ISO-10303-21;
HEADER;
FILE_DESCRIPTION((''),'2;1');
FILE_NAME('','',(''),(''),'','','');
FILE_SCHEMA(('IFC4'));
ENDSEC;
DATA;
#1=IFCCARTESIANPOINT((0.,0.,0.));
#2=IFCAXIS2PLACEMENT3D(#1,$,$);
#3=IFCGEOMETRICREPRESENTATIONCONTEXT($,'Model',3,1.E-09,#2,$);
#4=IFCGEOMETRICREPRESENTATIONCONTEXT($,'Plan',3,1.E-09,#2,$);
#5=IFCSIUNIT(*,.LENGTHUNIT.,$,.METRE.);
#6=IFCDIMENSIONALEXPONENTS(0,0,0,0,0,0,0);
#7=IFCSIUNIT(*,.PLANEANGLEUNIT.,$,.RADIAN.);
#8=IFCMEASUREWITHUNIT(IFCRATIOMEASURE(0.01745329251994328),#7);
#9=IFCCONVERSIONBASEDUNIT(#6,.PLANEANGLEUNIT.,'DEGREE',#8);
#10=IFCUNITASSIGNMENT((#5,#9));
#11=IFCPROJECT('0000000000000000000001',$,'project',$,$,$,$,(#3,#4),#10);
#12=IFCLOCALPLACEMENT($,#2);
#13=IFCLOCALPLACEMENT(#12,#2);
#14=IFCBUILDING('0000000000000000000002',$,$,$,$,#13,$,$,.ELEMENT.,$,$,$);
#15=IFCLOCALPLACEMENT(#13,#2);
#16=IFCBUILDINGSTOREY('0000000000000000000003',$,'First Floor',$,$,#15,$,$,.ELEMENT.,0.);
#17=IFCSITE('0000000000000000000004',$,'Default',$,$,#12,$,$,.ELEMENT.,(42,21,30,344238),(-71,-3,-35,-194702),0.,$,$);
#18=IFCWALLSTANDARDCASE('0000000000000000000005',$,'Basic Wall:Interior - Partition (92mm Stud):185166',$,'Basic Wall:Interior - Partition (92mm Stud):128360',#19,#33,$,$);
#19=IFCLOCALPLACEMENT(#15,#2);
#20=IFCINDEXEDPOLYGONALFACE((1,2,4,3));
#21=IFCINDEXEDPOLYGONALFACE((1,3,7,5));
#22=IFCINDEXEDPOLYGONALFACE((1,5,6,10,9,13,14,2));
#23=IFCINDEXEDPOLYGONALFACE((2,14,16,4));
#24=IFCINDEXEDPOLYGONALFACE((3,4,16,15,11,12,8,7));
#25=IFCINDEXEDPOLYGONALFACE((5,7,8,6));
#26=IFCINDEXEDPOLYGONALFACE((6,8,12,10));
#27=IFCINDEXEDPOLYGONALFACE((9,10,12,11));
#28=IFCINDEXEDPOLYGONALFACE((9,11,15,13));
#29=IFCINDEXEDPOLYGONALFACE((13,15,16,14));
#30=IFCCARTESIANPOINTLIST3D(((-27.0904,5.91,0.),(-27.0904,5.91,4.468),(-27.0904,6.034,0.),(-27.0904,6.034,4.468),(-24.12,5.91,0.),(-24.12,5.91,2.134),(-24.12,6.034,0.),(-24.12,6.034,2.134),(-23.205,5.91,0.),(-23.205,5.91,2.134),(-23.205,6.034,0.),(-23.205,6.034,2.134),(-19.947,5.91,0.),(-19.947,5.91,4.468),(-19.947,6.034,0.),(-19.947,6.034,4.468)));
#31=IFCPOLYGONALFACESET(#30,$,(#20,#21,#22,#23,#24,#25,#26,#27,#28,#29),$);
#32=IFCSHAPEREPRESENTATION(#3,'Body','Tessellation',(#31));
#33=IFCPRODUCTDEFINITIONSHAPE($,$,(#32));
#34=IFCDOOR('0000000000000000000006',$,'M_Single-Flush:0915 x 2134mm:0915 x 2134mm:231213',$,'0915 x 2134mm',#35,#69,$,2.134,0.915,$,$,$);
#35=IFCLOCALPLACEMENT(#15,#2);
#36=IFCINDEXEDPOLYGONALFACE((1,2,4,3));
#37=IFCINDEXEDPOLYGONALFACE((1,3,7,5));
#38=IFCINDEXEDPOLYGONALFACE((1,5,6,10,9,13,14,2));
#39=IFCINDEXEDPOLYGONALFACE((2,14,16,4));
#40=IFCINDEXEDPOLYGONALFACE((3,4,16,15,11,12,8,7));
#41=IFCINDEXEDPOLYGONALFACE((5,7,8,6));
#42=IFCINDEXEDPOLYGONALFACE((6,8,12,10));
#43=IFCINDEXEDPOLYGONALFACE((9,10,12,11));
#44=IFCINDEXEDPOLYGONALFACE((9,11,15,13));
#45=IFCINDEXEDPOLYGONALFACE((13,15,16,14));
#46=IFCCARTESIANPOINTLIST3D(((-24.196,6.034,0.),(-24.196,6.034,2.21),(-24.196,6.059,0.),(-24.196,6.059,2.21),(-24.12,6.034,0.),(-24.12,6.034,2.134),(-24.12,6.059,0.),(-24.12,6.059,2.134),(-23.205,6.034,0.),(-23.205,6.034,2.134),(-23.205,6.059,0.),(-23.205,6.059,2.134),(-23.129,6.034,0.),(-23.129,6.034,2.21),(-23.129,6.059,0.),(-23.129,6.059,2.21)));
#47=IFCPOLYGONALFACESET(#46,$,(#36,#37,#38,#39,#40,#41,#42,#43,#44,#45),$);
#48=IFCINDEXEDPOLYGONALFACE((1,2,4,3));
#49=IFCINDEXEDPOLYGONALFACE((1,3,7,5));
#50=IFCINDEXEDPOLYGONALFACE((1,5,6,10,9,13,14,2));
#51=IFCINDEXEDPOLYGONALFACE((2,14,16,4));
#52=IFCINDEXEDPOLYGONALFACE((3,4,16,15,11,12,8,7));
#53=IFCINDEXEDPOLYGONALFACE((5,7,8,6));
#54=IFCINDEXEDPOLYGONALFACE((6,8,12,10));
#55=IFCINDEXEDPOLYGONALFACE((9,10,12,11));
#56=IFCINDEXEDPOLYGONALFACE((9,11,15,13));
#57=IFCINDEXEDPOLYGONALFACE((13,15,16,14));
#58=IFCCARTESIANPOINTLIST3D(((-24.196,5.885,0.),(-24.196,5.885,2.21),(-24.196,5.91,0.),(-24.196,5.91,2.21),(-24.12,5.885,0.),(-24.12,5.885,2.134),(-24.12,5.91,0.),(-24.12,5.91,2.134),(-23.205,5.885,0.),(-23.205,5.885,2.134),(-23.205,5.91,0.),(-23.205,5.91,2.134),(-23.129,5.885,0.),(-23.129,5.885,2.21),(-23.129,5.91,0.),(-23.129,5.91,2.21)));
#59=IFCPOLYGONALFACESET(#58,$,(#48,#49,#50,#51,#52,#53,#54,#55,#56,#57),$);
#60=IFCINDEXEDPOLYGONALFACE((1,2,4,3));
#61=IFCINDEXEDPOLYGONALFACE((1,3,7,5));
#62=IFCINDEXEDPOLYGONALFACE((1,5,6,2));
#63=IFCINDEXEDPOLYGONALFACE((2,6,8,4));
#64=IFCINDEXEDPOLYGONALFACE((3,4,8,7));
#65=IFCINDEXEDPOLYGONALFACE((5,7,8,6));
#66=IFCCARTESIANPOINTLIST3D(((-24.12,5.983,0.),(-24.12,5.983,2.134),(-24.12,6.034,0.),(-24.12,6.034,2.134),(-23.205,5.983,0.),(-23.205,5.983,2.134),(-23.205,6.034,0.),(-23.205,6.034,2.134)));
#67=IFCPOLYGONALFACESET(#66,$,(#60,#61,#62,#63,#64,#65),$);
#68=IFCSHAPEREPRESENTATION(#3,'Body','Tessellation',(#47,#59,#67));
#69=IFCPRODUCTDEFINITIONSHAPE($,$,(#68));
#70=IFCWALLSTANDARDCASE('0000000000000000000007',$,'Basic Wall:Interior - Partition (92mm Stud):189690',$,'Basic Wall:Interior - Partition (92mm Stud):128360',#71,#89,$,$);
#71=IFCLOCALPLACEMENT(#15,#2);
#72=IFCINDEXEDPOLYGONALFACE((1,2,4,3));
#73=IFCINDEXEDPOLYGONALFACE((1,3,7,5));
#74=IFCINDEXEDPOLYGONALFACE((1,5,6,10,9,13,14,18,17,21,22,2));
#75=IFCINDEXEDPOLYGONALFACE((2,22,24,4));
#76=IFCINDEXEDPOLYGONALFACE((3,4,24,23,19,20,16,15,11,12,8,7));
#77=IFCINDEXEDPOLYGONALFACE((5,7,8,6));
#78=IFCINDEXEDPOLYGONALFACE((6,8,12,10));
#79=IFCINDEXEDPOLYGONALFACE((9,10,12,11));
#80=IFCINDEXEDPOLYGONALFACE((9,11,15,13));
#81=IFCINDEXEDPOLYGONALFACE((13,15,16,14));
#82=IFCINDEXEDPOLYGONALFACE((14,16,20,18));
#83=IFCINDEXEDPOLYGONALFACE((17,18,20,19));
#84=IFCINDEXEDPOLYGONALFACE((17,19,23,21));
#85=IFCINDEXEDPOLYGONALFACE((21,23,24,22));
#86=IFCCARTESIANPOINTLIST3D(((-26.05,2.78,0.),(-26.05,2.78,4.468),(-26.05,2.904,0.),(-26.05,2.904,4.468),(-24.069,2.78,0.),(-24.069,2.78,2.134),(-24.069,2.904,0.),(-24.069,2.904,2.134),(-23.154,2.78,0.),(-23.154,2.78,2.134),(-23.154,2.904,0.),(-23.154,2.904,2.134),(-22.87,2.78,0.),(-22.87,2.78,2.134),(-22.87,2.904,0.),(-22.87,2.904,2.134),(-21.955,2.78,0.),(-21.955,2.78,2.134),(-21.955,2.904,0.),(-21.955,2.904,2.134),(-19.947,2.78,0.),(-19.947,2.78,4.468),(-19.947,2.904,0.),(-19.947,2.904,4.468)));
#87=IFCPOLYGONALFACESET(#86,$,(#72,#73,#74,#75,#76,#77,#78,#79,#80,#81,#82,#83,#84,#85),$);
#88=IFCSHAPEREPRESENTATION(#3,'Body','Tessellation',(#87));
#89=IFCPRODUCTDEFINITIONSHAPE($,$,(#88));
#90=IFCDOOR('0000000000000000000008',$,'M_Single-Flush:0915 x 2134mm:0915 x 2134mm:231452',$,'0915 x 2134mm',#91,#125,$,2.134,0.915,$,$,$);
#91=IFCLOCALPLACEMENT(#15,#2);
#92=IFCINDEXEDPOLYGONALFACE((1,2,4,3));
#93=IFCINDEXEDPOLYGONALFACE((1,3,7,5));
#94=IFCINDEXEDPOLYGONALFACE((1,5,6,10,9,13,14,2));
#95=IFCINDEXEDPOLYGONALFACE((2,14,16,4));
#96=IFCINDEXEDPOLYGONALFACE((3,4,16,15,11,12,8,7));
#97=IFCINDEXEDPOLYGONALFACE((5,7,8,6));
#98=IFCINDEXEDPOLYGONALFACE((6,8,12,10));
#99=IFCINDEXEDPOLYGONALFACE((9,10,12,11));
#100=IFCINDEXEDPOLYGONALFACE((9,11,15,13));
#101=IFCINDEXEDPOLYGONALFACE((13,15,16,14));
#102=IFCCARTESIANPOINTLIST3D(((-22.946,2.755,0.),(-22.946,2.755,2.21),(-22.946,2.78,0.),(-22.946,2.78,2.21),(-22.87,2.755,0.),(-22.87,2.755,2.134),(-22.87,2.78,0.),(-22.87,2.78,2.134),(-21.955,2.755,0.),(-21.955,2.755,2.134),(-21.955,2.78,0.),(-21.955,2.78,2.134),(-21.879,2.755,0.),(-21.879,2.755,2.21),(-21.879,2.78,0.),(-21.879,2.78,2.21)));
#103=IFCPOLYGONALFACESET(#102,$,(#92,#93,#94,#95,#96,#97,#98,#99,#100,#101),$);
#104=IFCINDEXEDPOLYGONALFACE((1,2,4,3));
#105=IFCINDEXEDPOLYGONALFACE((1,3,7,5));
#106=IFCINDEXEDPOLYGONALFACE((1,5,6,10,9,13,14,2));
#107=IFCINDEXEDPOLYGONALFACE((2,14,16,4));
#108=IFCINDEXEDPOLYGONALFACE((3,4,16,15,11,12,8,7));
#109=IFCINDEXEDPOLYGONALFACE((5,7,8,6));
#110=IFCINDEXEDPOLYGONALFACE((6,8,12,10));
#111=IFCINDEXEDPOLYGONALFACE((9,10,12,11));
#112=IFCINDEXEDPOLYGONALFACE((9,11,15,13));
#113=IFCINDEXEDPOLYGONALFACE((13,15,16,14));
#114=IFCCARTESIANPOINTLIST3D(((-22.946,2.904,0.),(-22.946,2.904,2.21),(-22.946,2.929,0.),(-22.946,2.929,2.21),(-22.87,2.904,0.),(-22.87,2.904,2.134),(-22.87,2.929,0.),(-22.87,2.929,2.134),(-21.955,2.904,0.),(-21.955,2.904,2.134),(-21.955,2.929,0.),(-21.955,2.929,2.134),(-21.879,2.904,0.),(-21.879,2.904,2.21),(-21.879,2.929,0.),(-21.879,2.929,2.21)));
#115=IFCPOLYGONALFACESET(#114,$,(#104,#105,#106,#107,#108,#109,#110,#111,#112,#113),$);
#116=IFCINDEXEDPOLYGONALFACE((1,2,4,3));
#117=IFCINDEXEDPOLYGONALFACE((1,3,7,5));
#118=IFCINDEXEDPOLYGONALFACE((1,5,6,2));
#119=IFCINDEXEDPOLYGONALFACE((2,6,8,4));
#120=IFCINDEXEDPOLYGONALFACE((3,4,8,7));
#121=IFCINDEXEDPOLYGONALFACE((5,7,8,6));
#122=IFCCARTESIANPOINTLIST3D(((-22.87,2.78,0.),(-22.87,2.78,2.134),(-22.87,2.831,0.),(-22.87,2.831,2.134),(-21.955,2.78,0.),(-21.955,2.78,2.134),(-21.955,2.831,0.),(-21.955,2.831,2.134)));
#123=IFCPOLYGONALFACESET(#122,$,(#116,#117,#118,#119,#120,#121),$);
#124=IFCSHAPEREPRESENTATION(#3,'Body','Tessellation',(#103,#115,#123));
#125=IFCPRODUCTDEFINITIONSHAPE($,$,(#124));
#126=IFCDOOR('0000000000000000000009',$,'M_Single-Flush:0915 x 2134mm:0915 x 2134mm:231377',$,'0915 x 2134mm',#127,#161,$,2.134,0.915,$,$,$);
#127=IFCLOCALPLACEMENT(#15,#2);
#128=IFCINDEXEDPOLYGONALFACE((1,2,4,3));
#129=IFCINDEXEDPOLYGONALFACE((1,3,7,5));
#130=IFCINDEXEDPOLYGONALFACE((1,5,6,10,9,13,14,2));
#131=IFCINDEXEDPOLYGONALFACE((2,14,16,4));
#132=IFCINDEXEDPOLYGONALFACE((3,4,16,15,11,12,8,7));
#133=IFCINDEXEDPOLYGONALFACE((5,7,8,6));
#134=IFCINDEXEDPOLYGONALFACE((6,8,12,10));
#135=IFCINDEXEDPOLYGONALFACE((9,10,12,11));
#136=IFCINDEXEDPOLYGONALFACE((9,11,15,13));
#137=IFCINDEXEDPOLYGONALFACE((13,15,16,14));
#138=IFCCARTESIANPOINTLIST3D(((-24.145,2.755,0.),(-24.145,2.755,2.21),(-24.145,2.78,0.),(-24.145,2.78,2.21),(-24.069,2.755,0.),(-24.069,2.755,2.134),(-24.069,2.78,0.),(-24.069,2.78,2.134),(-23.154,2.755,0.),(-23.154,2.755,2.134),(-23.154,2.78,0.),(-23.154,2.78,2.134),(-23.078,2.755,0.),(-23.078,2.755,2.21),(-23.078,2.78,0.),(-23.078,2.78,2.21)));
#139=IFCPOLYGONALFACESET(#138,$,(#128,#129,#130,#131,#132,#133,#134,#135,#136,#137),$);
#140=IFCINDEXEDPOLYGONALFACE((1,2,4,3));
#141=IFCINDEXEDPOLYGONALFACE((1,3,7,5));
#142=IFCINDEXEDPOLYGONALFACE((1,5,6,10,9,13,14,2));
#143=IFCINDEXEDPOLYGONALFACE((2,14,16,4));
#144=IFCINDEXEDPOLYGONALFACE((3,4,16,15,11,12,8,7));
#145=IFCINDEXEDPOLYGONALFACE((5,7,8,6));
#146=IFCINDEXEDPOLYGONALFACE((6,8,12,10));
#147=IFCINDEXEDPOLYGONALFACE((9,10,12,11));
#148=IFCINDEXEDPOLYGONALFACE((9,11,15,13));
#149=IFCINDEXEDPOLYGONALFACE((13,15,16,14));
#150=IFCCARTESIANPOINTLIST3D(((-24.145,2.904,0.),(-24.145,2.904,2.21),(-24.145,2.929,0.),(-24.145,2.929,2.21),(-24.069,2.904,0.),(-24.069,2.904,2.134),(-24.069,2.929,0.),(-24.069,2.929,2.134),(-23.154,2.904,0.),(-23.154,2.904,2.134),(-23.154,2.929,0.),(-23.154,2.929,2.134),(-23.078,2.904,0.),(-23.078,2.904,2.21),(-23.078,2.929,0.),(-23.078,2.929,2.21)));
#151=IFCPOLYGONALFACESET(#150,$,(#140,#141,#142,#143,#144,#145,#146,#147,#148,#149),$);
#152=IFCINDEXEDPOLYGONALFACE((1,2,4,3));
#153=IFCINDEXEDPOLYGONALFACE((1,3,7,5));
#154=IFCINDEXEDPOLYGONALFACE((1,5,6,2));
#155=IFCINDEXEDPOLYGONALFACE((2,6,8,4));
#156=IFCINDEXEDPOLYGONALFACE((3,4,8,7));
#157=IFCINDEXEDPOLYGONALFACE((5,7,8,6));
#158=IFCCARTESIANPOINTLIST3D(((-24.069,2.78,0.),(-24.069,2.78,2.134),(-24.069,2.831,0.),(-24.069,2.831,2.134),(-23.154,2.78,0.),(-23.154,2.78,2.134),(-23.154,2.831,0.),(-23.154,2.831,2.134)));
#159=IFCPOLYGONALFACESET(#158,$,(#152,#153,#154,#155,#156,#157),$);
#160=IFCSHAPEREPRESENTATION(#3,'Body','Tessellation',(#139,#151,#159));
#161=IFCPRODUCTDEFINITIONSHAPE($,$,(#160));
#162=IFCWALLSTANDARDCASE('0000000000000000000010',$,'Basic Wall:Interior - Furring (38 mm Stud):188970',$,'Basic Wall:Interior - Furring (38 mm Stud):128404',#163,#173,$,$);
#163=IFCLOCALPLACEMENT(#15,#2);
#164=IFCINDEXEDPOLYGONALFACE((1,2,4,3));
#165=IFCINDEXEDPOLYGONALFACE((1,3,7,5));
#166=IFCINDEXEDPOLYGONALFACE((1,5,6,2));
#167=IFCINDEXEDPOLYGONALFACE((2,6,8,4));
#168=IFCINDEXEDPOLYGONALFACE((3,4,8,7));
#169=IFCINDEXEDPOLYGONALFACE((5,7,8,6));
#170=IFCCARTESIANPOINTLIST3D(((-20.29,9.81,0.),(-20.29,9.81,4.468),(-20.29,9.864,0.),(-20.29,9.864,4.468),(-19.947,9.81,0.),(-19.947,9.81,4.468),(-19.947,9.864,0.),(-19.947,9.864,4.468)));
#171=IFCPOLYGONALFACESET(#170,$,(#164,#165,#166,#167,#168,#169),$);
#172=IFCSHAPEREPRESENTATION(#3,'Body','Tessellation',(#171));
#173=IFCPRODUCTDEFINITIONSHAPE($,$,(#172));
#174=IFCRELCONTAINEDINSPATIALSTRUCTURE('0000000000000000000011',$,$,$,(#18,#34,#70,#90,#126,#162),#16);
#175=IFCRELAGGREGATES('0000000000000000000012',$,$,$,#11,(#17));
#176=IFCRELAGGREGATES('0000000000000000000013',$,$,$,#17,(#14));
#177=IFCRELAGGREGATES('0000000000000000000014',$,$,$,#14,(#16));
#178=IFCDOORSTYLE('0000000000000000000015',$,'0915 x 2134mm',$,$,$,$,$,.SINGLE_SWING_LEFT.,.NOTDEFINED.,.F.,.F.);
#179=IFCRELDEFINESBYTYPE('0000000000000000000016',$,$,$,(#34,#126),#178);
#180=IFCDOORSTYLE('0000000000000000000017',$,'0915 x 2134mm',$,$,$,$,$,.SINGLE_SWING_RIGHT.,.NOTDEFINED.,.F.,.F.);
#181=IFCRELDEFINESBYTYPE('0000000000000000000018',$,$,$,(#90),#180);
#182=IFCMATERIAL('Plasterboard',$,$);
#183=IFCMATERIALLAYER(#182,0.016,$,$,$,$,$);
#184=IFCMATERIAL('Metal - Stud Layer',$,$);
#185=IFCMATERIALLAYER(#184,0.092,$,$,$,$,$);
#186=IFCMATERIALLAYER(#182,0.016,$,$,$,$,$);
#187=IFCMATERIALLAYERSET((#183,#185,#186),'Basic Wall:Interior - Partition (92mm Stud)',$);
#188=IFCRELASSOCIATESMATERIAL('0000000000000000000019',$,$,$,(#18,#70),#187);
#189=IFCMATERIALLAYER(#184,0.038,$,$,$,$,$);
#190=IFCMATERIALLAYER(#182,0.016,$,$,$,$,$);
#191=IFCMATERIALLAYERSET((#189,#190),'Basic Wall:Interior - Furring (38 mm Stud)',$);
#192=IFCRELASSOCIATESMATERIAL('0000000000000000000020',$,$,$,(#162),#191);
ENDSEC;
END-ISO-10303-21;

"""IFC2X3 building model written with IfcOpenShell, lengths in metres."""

from ifc_helpers import new_model, entity, si_unit, converted_unit, frame, frame_2d, origin, origin_2d_with_axis, place, context, project, spatial, polyline, rectangle, outline, extrude, source, transform, mapped, material, layer, layer_set, layer_usage, type_object, type_shapes, element, fill, save


model = new_model("IFC2X3")

# Units and contexts
model_context = context("Model", 3, precision=1e-09, world=origin())
plan_context = context("Plan", 3, precision=1e-09, world=origin())
ifc_project = project(units=[si_unit("LENGTHUNIT", "METRE"), converted_unit("PLANEANGLEUNIT", "DEGREE", entity("IfcRatioMeasure", 0.01745329251994328), si_unit("PLANEANGLEUNIT", "RADIAN"), dimensions=[0, 0, 0, 0, 0, 0, 0])], contexts=[model_context, plan_context])

# Site, building, storey
site_placement = place(None, origin())
site = spatial("IfcSite", under=ifc_project, at=site_placement, Name="Default", CompositionType="ELEMENT", RefLatitude=(42, 21, 30, 344238), RefLongitude=(-71, -3, -35, -194702), RefElevation=0.0)
building_placement = place(site_placement, origin())
building = spatial("IfcBuilding", under=site, at=building_placement, CompositionType="ELEMENT")
storey_placement = place(building_placement, origin())
storey = spatial("IfcBuildingStorey", under=building, at=storey_placement, Name="First Floor", CompositionType="ELEMENT", Elevation=0.0)

# Shared definitions
ifc_material_1 = material(Name="Metal - Stud Layer")
ifc_material_2 = material(Name="Plasterboard")

# Wall, opening, door
ifc_layer_1 = layer(ifc_material_2, 0.016)
ifc_layer_2 = layer(ifc_material_1, 0.092)
ifc_layer_3 = layer(ifc_material_2, 0.016)
ifc_layer_set_1 = layer_set([ifc_layer_1, ifc_layer_2, ifc_layer_3], Name="Basic Wall:Interior - Partition (92mm Stud)")
ifc_layer_usage_1 = layer_usage(ifc_layer_set_1, "AXIS2", "NEGATIVE", 0.062)
wall_1_placement = place(storey_placement, frame((-19.947, 5.972, 0.0), z_axis=(0.0, 0.0, 1.0), x_axis=(-1.0, 0.0, 0.0)))
wall_1 = element("IfcWallStandardCase", 1, at=wall_1_placement, inside=storey, material=ifc_layer_usage_1, Name="Basic Wall:Interior - Partition (92mm Stud):185166", ObjectType="Basic Wall:Interior - Partition (92mm Stud):128360", context=model_context, shape_type="SweptSolid", body=[
    extrude(rectangle(XDim=7.1434, YDim=0.124, at=frame_2d((3.5717, 0.0), x_axis=(-1.0, 0.0))), origin(), (0.0, 0.0, 1.0), 4.468),
])
opening_1_placement = place(wall_1_placement, frame((4.173, 0.062, 0.0)))
opening_1 = element("IfcOpeningElement", 2, at=opening_1_placement, cuts=wall_1, ObjectType="Opening", context=model_context, shape_type="SweptSolid", body=[
    extrude(rectangle(XDim=0.915, YDim=2.134, at=frame_2d((1.067, 0.4575), x_axis=(0.0, -1.0))), frame((0.0, 0.0, 0.0), z_axis=(0.0, -1.0, 0.0), x_axis=(0.0, 0.0, 1.0)), (0.0, 0.0, 1.0), 0.124),
])
door_style_1 = type_object("IfcDoorStyle", Name="0915 x 2134mm", ConstructionType="NOTDEFINED", OperationType="SINGLE_SWING_LEFT", ParameterTakesPrecedence=False, Sizeable=False)
shared_shape_1 = source(origin(), model_context, "Body", "SweptSolid", [
    extrude(outline(polyline([(-0.5335, -1.124), (0.5335, -1.124), (0.5335, 1.086), (0.4575, 1.086), (0.4575, -1.048), (-0.4575, -1.048), (-0.4575, 1.086), (-0.5335, 1.086), (-0.5335, -1.124)])), frame((0.4575, 0.149, 1.086), z_axis=(0.0, -1.0, 0.0), x_axis=(-1.0, 0.0, 0.0)), (0.0, 0.0, 1.0), 0.025),
    extrude(outline(polyline([(-1.124, -0.5335), (1.086, -0.5335), (1.086, -0.4575), (-1.048, -0.4575), (-1.048, 0.4575), (1.086, 0.4575), (1.086, 0.5335), (-1.124, 0.5335), (-1.124, -0.5335)])), frame((0.4575, 0.0, 1.086), z_axis=(0.0, -1.0, 0.0), x_axis=(0.0, 0.0, -1.0)), (0.0, 0.0, 1.0), 0.025),
    extrude(rectangle(XDim=0.915, YDim=0.051, at=origin_2d_with_axis()), frame((0.4575, 0.0985, 0.0)), (0.0, 0.0, 1.0), 2.134),
])
type_shapes(door_style_1, [shared_shape_1])
door_1_placement = place(opening_1_placement, frame((0.0, 0.0, 0.0), z_axis=(0.0, 0.0, 1.0), x_axis=(-1.0, 0.0, 0.0)))
door_1 = element("IfcDoor", 3, at=door_1_placement, inside=storey, type_object=door_style_1, Name="M_Single-Flush:0915 x 2134mm:0915 x 2134mm:231213", ObjectType="0915 x 2134mm", OverallHeight=2.134, OverallWidth=0.915, context=model_context, shape_type="MappedRepresentation", body=[
    mapped(shared_shape_1, transform((0.0, 0.0, 0.0), scale=1.0)),
])
fill(opening_1, door_1)

# Wall, openings, doors
wall_2_placement = place(storey_placement, frame((-19.947, 2.842, 0.0), z_axis=(0.0, 0.0, 1.0), x_axis=(-1.0, 0.0, 0.0)))
wall_2 = element("IfcWallStandardCase", 4, at=wall_2_placement, inside=storey, material=ifc_layer_usage_1, Name="Basic Wall:Interior - Partition (92mm Stud):189690", ObjectType="Basic Wall:Interior - Partition (92mm Stud):128360", context=model_context, shape_type="SweptSolid", body=[
    extrude(rectangle(XDim=6.103, YDim=0.124, at=frame_2d((3.0515, 0.0), x_axis=(-1.0, 0.0))), origin(), (0.0, 0.0, 1.0), 4.468),
])
opening_2_placement = place(wall_2_placement, frame((2.008, -0.062, 0.0)))
opening_2 = element("IfcOpeningElement", 5, at=opening_2_placement, cuts=wall_2, ObjectType="Opening", context=model_context, shape_type="SweptSolid", body=[
    extrude(rectangle(XDim=0.915, YDim=2.134, at=frame_2d((1.067, 0.4575), x_axis=(0.0, 1.0))), frame((0.0, 0.0, 0.0), z_axis=(0.0, 1.0, 0.0), x_axis=(0.0, 0.0, 1.0)), (0.0, 0.0, 1.0), 0.124),
])
opening_3_placement = place(wall_2_placement, frame((3.207, -0.062, 0.0)))
opening_3 = element("IfcOpeningElement", 6, at=opening_3_placement, cuts=wall_2, ObjectType="Opening", context=model_context, shape_type="SweptSolid", body=[
    extrude(rectangle(XDim=0.915, YDim=2.134, at=frame_2d((1.067, 0.4575), x_axis=(0.0, -1.0))), frame((0.0, 0.0, 0.0), z_axis=(0.0, 1.0, 0.0), x_axis=(0.0, 0.0, 1.0)), (0.0, 0.0, 1.0), 0.124),
])
door_style_2 = type_object("IfcDoorStyle", Name="0915 x 2134mm", ConstructionType="NOTDEFINED", OperationType="SINGLE_SWING_RIGHT", ParameterTakesPrecedence=False, Sizeable=False)
shared_shape_2 = source(origin(), model_context, "Body", "SweptSolid", [
    extrude(outline(polyline([(-0.5335, -1.124), (0.5335, -1.124), (0.5335, 1.086), (0.4575, 1.086), (0.4575, -1.048), (-0.4575, -1.048), (-0.4575, 1.086), (-0.5335, 1.086), (-0.5335, -1.124)])), frame((0.4575, 0.124, 1.086), z_axis=(0.0, 1.0, 0.0), x_axis=(1.0, 0.0, 0.0)), (0.0, 0.0, 1.0), 0.025),
    extrude(outline(polyline([(-1.124, -0.5335), (1.086, -0.5335), (1.086, -0.4575), (-1.048, -0.4575), (-1.048, 0.4575), (1.086, 0.4575), (1.086, 0.5335), (-1.124, 0.5335), (-1.124, -0.5335)])), frame((0.4575, -0.025, 1.086), z_axis=(0.0, 1.0, 0.0), x_axis=(0.0, 0.0, -1.0)), (0.0, 0.0, 1.0), 0.025),
    extrude(rectangle(XDim=0.051, YDim=0.915, at=origin_2d_with_axis()), frame((0.4575, 0.0985, 0.0), z_axis=(0.0, 0.0, 1.0), x_axis=(0.0, 1.0, 0.0)), (0.0, 0.0, 1.0), 2.134),
])
type_shapes(door_style_2, [shared_shape_2])
door_2_placement = place(opening_2_placement, origin())
door_2 = element("IfcDoor", 7, at=door_2_placement, inside=storey, type_object=door_style_2, Name="M_Single-Flush:0915 x 2134mm:0915 x 2134mm:231452", ObjectType="0915 x 2134mm", OverallHeight=2.134, OverallWidth=0.915, context=model_context, shape_type="MappedRepresentation", body=[
    mapped(shared_shape_2, transform((0.0, 0.0, 0.0), scale=1.0)),
])
fill(opening_2, door_2)
door_3_placement = place(opening_3_placement, origin())
door_3 = element("IfcDoor", 8, at=door_3_placement, inside=storey, type_object=door_style_1, Name="M_Single-Flush:0915 x 2134mm:0915 x 2134mm:231377", ObjectType="0915 x 2134mm", OverallHeight=2.134, OverallWidth=0.915, context=model_context, shape_type="MappedRepresentation", body=[
    mapped(shared_shape_1, transform((0.0, 0.0, 0.0), scale=1.0)),
])
fill(opening_3, door_3)

# Wall
ifc_layer_4 = layer(ifc_material_1, 0.038)
ifc_layer_5 = layer(ifc_material_2, 0.016)
ifc_layer_set_2 = layer_set([ifc_layer_4, ifc_layer_5], Name="Basic Wall:Interior - Furring (38 mm Stud)")
ifc_layer_usage_2 = layer_usage(ifc_layer_set_2, "AXIS2", "POSITIVE", -0.027)
wall_3_placement = place(storey_placement, frame((-19.947, 9.837, 0.0), z_axis=(0.0, 0.0, 1.0), x_axis=(-1.0, 0.0, 0.0)))
element("IfcWallStandardCase", 9, at=wall_3_placement, inside=storey, material=ifc_layer_usage_2, Name="Basic Wall:Interior - Furring (38 mm Stud):188970", ObjectType="Basic Wall:Interior - Furring (38 mm Stud):128404", context=model_context, shape_type="SweptSolid", body=[
    extrude(rectangle(XDim=0.343, YDim=0.054, at=frame_2d((0.1715, 0.0), x_axis=(-1.0, 0.0))), origin(), (0.0, 0.0, 1.0), 4.468),
])

save(model, "model.ifc")
